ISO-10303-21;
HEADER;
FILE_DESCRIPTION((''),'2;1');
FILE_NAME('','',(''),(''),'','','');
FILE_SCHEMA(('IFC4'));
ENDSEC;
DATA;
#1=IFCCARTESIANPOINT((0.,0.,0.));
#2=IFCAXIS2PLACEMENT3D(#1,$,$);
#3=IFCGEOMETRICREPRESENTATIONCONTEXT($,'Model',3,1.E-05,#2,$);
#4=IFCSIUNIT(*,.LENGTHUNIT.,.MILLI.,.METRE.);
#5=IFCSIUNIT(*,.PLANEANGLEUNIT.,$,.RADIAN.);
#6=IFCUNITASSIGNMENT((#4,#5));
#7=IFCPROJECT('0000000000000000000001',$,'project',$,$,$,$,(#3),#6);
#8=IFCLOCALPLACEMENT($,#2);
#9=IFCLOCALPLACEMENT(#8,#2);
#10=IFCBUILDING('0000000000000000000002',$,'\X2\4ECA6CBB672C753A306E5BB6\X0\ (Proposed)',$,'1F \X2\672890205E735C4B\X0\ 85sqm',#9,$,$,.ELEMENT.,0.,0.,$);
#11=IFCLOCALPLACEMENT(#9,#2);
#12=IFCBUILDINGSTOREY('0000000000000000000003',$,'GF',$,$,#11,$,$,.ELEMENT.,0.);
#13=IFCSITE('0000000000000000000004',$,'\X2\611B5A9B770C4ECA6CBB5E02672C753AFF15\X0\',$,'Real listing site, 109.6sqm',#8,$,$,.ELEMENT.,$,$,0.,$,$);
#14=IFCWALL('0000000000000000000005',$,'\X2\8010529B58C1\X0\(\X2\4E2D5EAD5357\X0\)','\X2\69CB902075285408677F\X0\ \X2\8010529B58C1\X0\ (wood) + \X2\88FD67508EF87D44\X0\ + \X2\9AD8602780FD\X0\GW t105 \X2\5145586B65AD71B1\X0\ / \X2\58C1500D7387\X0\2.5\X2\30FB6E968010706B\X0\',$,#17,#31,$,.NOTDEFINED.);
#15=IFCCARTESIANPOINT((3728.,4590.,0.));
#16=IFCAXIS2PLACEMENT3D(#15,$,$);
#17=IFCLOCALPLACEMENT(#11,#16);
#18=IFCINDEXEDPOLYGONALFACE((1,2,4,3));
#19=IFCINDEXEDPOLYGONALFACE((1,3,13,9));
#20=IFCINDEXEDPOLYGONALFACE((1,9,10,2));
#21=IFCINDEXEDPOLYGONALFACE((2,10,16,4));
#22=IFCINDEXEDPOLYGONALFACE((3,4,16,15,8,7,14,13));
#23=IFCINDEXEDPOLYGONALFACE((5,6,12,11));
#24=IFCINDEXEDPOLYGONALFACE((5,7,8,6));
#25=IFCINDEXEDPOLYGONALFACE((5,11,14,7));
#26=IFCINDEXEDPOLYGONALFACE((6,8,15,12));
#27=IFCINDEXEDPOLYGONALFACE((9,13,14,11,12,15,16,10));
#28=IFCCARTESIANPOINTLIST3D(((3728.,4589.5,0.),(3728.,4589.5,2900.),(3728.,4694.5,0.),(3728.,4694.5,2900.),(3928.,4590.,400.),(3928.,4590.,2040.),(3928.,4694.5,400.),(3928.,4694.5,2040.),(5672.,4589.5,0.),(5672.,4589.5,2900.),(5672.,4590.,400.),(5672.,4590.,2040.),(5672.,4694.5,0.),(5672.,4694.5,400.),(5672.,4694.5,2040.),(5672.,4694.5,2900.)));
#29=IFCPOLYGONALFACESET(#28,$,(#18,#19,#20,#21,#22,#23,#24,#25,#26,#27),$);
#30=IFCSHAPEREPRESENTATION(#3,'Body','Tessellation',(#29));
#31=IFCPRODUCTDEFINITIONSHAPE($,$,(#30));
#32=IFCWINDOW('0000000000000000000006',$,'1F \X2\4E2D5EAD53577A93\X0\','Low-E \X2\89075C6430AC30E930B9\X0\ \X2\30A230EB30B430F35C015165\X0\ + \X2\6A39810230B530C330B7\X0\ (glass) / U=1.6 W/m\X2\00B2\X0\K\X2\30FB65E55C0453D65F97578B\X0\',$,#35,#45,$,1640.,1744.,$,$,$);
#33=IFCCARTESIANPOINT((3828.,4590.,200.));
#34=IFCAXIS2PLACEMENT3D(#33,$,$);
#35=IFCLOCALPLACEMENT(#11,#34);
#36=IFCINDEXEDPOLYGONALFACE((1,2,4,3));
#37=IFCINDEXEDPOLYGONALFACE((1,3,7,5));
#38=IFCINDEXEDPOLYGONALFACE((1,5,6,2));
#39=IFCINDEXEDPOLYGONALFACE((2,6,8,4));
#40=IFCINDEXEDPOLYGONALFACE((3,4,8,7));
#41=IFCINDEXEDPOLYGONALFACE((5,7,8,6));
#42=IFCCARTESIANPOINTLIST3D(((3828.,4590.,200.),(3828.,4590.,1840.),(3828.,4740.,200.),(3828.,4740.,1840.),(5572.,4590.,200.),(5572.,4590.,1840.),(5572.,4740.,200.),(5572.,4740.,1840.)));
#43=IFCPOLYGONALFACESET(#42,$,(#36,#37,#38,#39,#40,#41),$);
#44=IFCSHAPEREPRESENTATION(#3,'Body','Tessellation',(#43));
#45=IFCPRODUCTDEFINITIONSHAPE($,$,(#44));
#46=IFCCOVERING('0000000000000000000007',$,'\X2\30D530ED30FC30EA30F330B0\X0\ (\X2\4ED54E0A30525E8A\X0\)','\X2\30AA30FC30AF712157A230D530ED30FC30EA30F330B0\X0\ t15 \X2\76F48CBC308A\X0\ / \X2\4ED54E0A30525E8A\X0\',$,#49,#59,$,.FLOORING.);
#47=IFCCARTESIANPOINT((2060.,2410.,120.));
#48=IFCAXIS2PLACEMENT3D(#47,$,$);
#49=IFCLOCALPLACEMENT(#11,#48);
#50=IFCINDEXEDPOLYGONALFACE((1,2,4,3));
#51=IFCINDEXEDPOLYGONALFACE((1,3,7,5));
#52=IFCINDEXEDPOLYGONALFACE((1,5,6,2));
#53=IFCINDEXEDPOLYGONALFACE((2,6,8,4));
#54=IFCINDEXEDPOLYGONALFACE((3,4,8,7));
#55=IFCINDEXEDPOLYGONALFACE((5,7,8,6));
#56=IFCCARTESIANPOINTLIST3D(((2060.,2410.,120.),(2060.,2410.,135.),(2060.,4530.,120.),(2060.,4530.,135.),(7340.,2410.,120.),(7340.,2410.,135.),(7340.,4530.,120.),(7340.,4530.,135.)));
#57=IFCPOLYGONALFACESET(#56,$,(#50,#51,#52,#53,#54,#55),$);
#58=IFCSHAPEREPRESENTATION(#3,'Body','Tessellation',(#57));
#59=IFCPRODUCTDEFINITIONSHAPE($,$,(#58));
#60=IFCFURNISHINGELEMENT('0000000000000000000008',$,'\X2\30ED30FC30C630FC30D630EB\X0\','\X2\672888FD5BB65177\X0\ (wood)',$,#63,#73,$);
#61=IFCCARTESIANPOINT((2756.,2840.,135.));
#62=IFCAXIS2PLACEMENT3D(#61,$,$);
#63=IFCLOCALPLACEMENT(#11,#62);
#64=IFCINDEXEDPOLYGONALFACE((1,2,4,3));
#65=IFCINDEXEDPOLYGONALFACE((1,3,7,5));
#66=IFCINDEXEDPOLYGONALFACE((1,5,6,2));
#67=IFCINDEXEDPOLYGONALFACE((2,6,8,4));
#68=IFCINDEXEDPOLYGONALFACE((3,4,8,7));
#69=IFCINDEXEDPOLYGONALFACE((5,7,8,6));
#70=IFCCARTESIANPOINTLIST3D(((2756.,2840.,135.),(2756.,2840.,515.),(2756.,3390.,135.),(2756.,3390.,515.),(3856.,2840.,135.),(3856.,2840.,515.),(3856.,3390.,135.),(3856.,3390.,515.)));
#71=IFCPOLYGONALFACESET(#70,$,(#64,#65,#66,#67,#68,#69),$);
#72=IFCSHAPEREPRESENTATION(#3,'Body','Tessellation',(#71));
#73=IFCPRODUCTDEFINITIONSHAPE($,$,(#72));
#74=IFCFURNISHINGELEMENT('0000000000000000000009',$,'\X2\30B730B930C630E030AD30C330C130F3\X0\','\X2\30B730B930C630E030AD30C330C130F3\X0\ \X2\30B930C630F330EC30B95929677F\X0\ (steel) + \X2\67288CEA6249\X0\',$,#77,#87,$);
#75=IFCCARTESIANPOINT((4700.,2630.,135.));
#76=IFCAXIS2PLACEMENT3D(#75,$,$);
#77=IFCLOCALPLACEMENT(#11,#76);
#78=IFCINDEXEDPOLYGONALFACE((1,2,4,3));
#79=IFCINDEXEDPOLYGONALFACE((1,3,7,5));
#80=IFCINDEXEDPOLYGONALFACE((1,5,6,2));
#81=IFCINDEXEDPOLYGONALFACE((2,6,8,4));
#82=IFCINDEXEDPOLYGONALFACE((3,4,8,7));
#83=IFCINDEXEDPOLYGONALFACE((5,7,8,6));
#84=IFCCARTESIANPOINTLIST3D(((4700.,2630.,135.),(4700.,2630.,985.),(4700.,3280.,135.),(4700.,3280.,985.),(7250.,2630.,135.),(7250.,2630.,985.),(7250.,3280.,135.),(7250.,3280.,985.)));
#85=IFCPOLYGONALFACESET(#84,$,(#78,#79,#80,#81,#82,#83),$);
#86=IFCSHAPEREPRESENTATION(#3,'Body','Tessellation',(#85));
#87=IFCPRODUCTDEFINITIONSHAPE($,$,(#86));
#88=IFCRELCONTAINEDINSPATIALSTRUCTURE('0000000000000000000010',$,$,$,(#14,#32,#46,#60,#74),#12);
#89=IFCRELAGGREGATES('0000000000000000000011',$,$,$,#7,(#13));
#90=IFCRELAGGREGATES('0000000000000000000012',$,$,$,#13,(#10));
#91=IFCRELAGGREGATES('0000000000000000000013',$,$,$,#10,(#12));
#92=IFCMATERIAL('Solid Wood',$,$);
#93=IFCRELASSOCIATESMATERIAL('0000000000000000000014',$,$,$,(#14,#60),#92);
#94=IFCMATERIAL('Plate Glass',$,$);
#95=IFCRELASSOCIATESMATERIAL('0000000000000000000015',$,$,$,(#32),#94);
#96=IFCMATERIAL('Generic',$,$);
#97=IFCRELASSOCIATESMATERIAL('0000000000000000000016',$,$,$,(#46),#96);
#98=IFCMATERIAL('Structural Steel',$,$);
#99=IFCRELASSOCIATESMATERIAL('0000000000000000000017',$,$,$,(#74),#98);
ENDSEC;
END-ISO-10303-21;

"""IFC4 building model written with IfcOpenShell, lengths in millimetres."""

from ifc_helpers import new_model, si_unit, frame, frame_2d, origin, place, context, project, spatial, rectangle, extrude, material, element, fill, save


model = new_model("IFC4")

# Units and contexts
model_context = context("Model", 3, precision=1e-05, world=origin())
ifc_project = project(units=[si_unit("LENGTHUNIT", "METRE", prefix="MILLI"), si_unit("PLANEANGLEUNIT", "RADIAN")], contexts=[model_context])

# Site, building, storey
site_placement = place(None, origin())
site = spatial("IfcSite", under=ifc_project, at=site_placement, Name="愛媛県今治市本町５", ObjectType="Real listing site, 109.6sqm", CompositionType="ELEMENT", RefElevation=0.0)
building_placement = place(site_placement, origin())
building = spatial("IfcBuilding", under=site, at=building_placement, Name="今治本町の家 (Proposed)", ObjectType="1F 木造平屋 85sqm", CompositionType="ELEMENT", ElevationOfRefHeight=0.0, ElevationOfTerrain=0.0)
storey_placement = place(building_placement, origin())
storey = spatial("IfcBuildingStorey", under=building, at=storey_placement, Name="GF", CompositionType="ELEMENT", Elevation=0.0)

# Shared definitions
ifc_material_1 = material(Name="Solid Wood")

# Shared definitions
ifc_material_2 = material(Name="Plate Glass")

# Wall, opening, window
wall_1_placement = place(storey_placement, frame((3728.0, 4590.0, 0.0)))
wall_1 = element("IfcWall", 1, at=wall_1_placement, inside=storey, material=ifc_material_1, Name="耐力壁(中庭南)", Description="構造用合板 耐力壁 (wood) + 製材軸組 + 高性能GW t105 充填断熱 / 壁倍率2.5・準耐火", PredefinedType="NOTDEFINED", context=model_context, shape_type="SweptSolid", body=[
    extrude(rectangle(XDim=1944.0, YDim=105.0, at=frame_2d((972.0, 52.0))), frame((3728.0, 4590.0, 0.0)), (0.0, 0.0, 1.0), 2900.0),
])
opening_1_placement = place(storey_placement, frame((3828.0, 4590.0, 200.0)))
opening_1 = element("IfcOpeningElement", 2, at=opening_1_placement, cuts=wall_1, PredefinedType="NOTDEFINED", context=model_context, shape_type="SweptSolid", body=[
    extrude(rectangle(XDim=1744.0, YDim=150.0, at=frame_2d((872.0, 75.0))), frame((3828.0, 4590.0, 200.0)), (0.0, 0.0, 1.0), 1640.0),
])
window_1_placement = place(storey_placement, frame((3828.0, 4590.0, 200.0)))
window_1 = element("IfcWindow", 3, at=window_1_placement, inside=storey, material=ifc_material_2, Name="1F 中庭南窓", Description="Low-E 複層ガラス アルゴン封入 + 樹脂サッシ (glass) / U=1.6 W/m²K・日射取得型", OverallHeight=1640.0, OverallWidth=1744.0, context=model_context, shape_type="SweptSolid", body=[
    extrude(rectangle(XDim=1744.0, YDim=150.0, at=frame_2d((872.0, 75.0))), frame((3828.0, 4590.0, 200.0)), (0.0, 0.0, 1.0), 1640.0),
])
fill(opening_1, window_1)

# Covering
ifc_material_3 = material(Name="Generic")
covering_placement = place(storey_placement, frame((2060.0, 2410.0, 120.0)))
element("IfcCovering", 4, at=covering_placement, inside=storey, material=ifc_material_3, Name="フローリング (仕上げ床)", Description="オーク無垢フローリング t15 直貼り / 仕上げ床", PredefinedType="FLOORING", context=model_context, shape_type="SweptSolid", body=[
    extrude(rectangle(XDim=5280.0, YDim=2120.0, at=frame_2d((2640.0, 1060.0))), frame((2060.0, 2410.0, 120.0)), (0.0, 0.0, 1.0), 15.0),
])

# Furnishing elements
furnishing_1_placement = place(storey_placement, frame((2756.0, 2840.0, 135.0)))
element("IfcFurnishingElement", 5, at=furnishing_1_placement, inside=storey, material=ifc_material_1, Name="ローテーブル", Description="木製家具 (wood)", context=model_context, shape_type="SweptSolid", body=[
    extrude(rectangle(XDim=1100.0, YDim=550.0, at=frame_2d((550.0, 275.0))), frame((2756.0, 2840.0, 135.0)), (0.0, 0.0, 1.0), 380.0),
])
ifc_material_4 = material(Name="Structural Steel")
furnishing_2_placement = place(storey_placement, frame((4700.0, 2630.0, 135.0)))
element("IfcFurnishingElement", 6, at=furnishing_2_placement, inside=storey, material=ifc_material_4, Name="システムキッチン", Description="システムキッチン ステンレス天板 (steel) + 木質扉", context=model_context, shape_type="SweptSolid", body=[
    extrude(rectangle(XDim=2550.0, YDim=650.0, at=frame_2d((1275.0, 325.0))), frame((4700.0, 2630.0, 135.0)), (0.0, 0.0, 1.0), 850.0),
])

save(model, "model.ifc")
